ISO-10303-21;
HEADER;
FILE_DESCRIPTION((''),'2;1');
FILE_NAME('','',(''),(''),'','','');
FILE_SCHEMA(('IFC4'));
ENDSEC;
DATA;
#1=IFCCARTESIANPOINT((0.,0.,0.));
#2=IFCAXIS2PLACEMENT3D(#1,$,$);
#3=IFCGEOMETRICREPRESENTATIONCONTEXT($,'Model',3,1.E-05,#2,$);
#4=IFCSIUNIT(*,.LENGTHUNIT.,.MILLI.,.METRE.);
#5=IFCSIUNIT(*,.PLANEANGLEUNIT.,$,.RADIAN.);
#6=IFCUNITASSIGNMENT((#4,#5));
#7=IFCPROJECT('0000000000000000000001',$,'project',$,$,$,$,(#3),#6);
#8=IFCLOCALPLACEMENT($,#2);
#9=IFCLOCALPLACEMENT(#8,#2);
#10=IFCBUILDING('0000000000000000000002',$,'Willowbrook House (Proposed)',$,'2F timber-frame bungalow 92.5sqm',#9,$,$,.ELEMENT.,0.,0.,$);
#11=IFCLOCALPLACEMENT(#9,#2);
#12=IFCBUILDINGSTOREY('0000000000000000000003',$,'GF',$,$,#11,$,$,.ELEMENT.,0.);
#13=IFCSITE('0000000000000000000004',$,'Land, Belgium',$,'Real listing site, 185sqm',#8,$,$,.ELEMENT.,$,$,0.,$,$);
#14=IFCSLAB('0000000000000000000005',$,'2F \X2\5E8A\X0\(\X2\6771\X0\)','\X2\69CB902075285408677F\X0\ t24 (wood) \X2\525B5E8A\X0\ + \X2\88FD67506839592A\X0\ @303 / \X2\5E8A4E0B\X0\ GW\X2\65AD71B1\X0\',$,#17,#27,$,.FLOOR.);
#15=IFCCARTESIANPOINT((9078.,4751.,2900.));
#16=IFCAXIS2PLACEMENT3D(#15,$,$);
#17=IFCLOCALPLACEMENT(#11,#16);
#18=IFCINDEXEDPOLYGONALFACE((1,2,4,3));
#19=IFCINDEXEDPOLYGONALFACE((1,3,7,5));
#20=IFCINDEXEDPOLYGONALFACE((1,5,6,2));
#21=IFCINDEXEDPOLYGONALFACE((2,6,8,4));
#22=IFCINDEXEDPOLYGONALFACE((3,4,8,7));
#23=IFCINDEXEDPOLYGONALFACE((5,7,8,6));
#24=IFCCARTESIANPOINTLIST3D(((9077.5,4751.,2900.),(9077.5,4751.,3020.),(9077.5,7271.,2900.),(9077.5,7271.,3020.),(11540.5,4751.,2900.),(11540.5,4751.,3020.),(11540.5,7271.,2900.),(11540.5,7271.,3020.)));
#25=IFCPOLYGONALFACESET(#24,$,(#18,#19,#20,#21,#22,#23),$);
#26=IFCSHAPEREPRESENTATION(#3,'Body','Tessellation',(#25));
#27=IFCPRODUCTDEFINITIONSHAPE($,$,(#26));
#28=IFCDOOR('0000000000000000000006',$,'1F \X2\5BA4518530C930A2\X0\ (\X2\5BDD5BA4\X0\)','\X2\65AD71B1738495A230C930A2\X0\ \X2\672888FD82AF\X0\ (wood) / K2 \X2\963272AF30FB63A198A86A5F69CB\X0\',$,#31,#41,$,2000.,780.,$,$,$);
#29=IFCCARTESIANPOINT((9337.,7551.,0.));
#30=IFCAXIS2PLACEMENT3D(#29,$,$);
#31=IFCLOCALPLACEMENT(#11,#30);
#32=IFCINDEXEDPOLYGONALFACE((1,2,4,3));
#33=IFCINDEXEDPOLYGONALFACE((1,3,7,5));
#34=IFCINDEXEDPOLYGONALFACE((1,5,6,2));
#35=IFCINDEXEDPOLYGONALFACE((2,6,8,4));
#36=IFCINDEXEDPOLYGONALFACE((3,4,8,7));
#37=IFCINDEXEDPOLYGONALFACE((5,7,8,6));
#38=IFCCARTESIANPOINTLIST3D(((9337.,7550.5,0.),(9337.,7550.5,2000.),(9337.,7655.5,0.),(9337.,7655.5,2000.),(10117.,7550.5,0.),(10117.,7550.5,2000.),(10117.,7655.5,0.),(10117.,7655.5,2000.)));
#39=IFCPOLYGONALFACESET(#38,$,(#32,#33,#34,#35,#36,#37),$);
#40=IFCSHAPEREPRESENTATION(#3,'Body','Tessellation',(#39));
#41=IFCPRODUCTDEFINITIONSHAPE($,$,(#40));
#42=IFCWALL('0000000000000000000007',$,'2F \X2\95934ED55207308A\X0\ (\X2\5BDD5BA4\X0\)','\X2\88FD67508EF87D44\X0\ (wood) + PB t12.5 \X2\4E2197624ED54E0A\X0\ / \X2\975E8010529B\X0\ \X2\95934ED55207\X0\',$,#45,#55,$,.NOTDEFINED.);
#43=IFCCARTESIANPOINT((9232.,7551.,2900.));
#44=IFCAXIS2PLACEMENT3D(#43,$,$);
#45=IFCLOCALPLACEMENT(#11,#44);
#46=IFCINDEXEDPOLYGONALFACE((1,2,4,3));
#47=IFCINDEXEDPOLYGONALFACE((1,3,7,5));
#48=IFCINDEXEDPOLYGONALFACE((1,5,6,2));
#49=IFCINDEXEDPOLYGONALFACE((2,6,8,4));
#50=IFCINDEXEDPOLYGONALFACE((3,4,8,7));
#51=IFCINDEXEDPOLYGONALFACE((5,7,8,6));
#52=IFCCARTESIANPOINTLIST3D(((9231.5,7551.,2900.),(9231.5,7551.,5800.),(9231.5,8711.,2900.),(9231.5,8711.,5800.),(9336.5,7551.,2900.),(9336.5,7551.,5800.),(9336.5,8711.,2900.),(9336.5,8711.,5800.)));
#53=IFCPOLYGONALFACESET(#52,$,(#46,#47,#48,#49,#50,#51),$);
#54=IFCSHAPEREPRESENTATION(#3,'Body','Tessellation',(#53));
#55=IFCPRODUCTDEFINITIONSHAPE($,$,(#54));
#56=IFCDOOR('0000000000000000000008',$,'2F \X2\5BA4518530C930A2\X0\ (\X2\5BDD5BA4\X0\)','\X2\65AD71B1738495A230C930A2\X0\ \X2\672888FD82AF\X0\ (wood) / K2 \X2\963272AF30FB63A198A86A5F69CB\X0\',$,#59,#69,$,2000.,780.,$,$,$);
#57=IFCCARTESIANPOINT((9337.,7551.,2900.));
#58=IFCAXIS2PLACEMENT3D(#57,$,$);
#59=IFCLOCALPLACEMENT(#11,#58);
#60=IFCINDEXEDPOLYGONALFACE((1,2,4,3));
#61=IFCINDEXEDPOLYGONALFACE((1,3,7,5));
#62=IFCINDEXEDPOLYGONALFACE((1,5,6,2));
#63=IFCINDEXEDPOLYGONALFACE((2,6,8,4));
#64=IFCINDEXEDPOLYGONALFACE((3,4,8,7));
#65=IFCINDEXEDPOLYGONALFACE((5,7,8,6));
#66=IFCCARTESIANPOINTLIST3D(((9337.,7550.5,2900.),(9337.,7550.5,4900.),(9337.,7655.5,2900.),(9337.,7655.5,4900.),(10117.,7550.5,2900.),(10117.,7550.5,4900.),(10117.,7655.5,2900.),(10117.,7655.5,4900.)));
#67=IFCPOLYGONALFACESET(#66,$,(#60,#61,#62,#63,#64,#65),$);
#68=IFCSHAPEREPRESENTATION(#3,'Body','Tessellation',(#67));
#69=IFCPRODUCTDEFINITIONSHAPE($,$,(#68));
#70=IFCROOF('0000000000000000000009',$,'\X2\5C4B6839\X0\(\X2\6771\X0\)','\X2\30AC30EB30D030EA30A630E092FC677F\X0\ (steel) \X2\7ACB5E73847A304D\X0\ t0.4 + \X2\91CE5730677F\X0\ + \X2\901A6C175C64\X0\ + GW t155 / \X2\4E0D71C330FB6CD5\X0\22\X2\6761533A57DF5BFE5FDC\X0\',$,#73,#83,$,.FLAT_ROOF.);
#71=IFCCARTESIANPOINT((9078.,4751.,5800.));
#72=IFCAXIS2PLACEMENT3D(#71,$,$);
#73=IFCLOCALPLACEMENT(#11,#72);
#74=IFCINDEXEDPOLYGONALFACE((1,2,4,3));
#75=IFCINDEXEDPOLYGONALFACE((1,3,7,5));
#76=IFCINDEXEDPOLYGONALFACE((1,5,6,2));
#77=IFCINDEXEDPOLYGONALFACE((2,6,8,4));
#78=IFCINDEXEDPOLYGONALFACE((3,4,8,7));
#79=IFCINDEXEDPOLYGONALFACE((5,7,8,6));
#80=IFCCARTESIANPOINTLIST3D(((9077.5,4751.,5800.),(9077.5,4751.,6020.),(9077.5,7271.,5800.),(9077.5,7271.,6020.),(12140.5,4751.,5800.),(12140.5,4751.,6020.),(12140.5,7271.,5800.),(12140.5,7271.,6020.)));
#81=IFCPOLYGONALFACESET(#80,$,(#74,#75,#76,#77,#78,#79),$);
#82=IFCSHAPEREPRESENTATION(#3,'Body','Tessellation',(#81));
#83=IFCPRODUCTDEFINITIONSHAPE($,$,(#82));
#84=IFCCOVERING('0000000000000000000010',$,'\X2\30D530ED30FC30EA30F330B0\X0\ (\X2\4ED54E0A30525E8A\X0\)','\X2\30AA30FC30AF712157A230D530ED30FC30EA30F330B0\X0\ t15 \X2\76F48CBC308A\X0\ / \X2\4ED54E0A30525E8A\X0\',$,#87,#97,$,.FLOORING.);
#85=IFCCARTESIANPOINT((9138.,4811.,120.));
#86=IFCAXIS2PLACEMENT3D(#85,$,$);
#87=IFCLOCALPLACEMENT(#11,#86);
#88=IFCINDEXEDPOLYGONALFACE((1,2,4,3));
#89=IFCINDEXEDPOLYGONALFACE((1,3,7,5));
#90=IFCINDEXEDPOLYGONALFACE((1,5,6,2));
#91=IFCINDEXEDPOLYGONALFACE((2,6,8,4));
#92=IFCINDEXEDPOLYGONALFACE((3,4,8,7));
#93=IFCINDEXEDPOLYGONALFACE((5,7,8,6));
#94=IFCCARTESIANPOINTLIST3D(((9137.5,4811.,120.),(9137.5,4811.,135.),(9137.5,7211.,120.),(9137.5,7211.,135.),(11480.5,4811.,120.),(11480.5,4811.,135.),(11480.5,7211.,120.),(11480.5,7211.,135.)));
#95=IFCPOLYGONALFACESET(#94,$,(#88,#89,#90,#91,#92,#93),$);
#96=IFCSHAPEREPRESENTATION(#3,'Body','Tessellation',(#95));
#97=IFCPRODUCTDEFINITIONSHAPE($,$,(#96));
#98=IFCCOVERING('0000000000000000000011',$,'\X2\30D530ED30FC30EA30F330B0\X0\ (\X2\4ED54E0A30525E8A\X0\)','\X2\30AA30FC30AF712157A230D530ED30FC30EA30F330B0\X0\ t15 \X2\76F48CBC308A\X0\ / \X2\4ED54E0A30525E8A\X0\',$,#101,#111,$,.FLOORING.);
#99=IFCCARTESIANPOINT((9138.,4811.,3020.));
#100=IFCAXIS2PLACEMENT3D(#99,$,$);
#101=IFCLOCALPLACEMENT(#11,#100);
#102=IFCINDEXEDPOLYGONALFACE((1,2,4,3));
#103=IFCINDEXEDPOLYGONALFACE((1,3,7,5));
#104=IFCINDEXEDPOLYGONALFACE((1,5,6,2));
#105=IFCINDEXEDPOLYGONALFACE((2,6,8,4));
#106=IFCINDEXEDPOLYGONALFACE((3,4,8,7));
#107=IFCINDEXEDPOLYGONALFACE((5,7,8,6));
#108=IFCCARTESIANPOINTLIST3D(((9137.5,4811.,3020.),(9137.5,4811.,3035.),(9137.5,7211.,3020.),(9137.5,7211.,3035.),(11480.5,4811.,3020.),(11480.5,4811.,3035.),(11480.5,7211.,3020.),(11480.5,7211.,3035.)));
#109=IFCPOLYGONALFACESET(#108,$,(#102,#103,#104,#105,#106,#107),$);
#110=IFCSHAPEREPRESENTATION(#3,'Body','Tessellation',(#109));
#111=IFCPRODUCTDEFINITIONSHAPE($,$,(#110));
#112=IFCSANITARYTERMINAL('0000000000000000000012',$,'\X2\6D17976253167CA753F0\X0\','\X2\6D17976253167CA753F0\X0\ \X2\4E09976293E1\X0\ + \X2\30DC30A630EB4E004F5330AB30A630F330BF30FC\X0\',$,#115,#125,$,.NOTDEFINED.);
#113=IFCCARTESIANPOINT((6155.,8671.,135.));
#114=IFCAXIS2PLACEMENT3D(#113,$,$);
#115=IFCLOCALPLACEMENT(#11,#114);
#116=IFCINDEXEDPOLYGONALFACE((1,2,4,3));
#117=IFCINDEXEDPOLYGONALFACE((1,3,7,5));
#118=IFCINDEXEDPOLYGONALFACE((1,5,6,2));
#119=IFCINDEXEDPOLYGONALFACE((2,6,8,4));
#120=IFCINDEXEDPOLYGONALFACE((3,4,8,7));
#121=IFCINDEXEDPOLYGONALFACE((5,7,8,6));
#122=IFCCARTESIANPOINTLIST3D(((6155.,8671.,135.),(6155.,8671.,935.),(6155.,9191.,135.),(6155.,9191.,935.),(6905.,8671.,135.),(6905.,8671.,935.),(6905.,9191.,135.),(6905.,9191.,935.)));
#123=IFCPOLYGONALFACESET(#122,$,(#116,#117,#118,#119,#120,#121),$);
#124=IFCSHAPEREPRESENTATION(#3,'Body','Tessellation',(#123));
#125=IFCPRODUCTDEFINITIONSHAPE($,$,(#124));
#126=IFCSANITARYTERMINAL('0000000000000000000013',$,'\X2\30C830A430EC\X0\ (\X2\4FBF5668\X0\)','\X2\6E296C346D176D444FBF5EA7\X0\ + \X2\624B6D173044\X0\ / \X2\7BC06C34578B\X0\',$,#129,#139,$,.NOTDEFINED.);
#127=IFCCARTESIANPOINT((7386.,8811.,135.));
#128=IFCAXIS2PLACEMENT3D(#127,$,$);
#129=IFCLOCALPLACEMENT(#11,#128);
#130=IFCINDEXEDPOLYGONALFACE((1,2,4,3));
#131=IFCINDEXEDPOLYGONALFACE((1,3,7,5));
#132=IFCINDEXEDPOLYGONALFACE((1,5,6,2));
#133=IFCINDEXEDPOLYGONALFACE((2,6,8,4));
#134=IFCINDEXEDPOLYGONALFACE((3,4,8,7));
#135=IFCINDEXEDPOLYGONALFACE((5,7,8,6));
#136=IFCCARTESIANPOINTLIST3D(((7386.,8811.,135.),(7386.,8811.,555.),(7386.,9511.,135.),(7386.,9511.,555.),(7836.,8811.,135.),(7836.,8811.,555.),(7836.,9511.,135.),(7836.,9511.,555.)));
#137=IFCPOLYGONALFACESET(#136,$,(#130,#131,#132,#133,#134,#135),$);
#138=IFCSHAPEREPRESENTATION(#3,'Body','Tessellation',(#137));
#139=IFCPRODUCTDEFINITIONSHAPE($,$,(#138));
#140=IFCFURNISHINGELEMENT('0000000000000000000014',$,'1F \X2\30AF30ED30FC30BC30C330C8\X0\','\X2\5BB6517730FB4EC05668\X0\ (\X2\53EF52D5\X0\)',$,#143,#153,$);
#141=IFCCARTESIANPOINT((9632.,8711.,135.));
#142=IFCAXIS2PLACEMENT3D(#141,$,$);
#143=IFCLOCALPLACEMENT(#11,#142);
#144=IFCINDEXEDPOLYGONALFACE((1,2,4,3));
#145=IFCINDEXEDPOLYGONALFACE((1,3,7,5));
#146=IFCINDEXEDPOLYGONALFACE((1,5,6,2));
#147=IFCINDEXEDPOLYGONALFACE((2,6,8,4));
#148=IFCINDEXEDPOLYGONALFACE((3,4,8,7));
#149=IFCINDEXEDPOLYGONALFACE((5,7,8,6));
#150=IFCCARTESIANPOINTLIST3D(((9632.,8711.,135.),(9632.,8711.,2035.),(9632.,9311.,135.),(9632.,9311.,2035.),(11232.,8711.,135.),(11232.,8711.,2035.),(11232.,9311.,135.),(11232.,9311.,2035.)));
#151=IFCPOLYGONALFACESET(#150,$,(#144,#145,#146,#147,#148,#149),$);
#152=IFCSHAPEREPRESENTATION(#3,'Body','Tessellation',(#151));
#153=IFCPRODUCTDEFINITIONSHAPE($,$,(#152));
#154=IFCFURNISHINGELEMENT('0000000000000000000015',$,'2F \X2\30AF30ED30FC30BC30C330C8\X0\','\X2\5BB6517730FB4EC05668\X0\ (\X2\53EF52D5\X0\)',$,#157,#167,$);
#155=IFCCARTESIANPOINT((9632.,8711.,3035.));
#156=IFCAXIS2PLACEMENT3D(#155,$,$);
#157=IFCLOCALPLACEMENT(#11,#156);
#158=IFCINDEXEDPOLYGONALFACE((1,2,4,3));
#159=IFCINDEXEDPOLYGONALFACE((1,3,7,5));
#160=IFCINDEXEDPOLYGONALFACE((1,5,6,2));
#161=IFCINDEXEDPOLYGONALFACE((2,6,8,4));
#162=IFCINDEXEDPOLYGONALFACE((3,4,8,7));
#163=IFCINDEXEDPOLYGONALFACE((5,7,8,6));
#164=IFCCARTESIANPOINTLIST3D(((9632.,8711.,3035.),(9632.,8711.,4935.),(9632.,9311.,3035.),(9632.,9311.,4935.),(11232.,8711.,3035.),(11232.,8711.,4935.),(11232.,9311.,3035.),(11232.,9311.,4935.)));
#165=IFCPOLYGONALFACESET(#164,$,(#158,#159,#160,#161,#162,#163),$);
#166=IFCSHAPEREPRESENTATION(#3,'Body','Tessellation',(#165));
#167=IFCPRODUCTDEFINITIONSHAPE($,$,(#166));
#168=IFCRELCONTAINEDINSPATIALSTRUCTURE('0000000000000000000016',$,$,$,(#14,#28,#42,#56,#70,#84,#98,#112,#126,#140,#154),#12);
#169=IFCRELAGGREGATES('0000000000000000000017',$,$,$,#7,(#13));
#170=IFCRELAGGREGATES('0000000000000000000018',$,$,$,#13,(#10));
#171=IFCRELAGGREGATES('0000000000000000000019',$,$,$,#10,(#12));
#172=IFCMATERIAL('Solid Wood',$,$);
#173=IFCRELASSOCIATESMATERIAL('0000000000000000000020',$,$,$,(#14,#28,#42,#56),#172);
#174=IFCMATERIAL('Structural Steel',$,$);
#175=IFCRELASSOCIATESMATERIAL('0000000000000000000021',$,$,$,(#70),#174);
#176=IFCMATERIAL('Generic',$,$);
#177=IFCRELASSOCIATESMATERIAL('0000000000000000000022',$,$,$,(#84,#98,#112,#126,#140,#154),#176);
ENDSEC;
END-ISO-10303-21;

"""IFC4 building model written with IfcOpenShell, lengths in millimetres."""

from ifc_helpers import new_model, si_unit, frame, frame_2d, origin, place, context, project, spatial, rectangle, extrude, material, element, save


model = new_model("IFC4")

# Units and contexts
model_context = context("Model", 3, precision=1e-05, world=origin())
ifc_project = project(units=[si_unit("LENGTHUNIT", "METRE", prefix="MILLI"), si_unit("PLANEANGLEUNIT", "RADIAN")], contexts=[model_context])

# Site, building, storey
site_placement = place(None, origin())
site = spatial("IfcSite", under=ifc_project, at=site_placement, Name="Land, Belgium", ObjectType="Real listing site, 185sqm", CompositionType="ELEMENT", RefElevation=0.0)
building_placement = place(site_placement, origin())
building = spatial("IfcBuilding", under=site, at=building_placement, Name="Willowbrook House (Proposed)", ObjectType="2F timber-frame bungalow 92.5sqm", CompositionType="ELEMENT", ElevationOfRefHeight=0.0, ElevationOfTerrain=0.0)
storey_placement = place(building_placement, origin())
storey = spatial("IfcBuildingStorey", under=building, at=storey_placement, Name="GF", CompositionType="ELEMENT", Elevation=0.0)

# Slab
ifc_material_1 = material(Name="Solid Wood")
slab_1_placement = place(storey_placement, frame((9078.0, 4751.0, 2900.0)))
element("IfcSlab", 1, at=slab_1_placement, inside=storey, material=ifc_material_1, Name="2F 床(東)", Description="構造用合板 t24 (wood) 剛床 + 製材根太 @303 / 床下 GW断熱", PredefinedType="FLOOR", context=model_context, shape_type="SweptSolid", body=[
    extrude(rectangle(XDim=2463.0, YDim=2520.0, at=frame_2d((1231.0, 1260.0))), frame((9078.0, 4751.0, 2900.0)), (0.0, 0.0, 1.0), 120.0),
])

# Door
door_1_placement = place(storey_placement, frame((9337.0, 7551.0, 0.0)))
element("IfcDoor", 2, at=door_1_placement, inside=storey, material=ifc_material_1, Name="1F 室内ドア (寝室)", Description="断熱玄関ドア 木製芯 (wood) / K2 防犯・採風機構", OverallHeight=2000.0, OverallWidth=780.0, context=model_context, shape_type="SweptSolid", body=[
    extrude(rectangle(XDim=780.0, YDim=105.0, at=frame_2d((390.0, 52.0))), frame((9337.0, 7551.0, 0.0)), (0.0, 0.0, 1.0), 2000.0),
])

# Wall
wall_1_placement = place(storey_placement, frame((9232.0, 7551.0, 2900.0)))
element("IfcWall", 3, at=wall_1_placement, inside=storey, material=ifc_material_1, Name="2F 間仕切り (寝室)", Description="製材軸組 (wood) + PB t12.5 両面仕上 / 非耐力 間仕切", PredefinedType="NOTDEFINED", context=model_context, shape_type="SweptSolid", body=[
    extrude(rectangle(XDim=105.0, YDim=1160.0, at=frame_2d((52.0, 580.0))), frame((9232.0, 7551.0, 2900.0)), (0.0, 0.0, 1.0), 2900.0),
])

# Door
door_2_placement = place(storey_placement, frame((9337.0, 7551.0, 2900.0)))
element("IfcDoor", 4, at=door_2_placement, inside=storey, material=ifc_material_1, Name="2F 室内ドア (寝室)", Description="断熱玄関ドア 木製芯 (wood) / K2 防犯・採風機構", OverallHeight=2000.0, OverallWidth=780.0, context=model_context, shape_type="SweptSolid", body=[
    extrude(rectangle(XDim=780.0, YDim=105.0, at=frame_2d((390.0, 52.0))), frame((9337.0, 7551.0, 2900.0)), (0.0, 0.0, 1.0), 2000.0),
])

# Roof
ifc_material_2 = material(Name="Structural Steel")
for number, where, name in (
    (5, (9078.0, 4751.0, 5800.0), "屋根(東)"),
):
    element("IfcRoof", number, at=place(storey_placement, frame(where)), inside=storey, material=ifc_material_2, Name=name, Description="ガルバリウム鋼板 (steel) 立平葺き t0.4 + 野地板 + 通気層 + GW t155 / 不燃・法22条区域対応", PredefinedType="FLAT_ROOF", context=model_context, shape_type="SweptSolid", body=[
        extrude(rectangle(XDim=3063.0, YDim=2520.0, at=frame_2d((1531.0, 1260.0))), frame((9078.0, 4751.0, 5800.0)), (0.0, 0.0, 1.0), 220.0),
    ])

# Coverings
ifc_material_3 = material(Name="Generic")
covering_1_placement = place(storey_placement, frame((9138.0, 4811.0, 120.0)))
element("IfcCovering", 6, at=covering_1_placement, inside=storey, material=ifc_material_3, Name="フローリング (仕上げ床)", Description="オーク無垢フローリング t15 直貼り / 仕上げ床", PredefinedType="FLOORING", context=model_context, shape_type="SweptSolid", body=[
    extrude(rectangle(XDim=2343.0, YDim=2400.0, at=frame_2d((1171.0, 1200.0))), frame((9138.0, 4811.0, 120.0)), (0.0, 0.0, 1.0), 15.0),
])
covering_2_placement = place(storey_placement, frame((9138.0, 4811.0, 3020.0)))
element("IfcCovering", 7, at=covering_2_placement, inside=storey, material=ifc_material_3, Name="フローリング (仕上げ床)", Description="オーク無垢フローリング t15 直貼り / 仕上げ床", PredefinedType="FLOORING", context=model_context, shape_type="SweptSolid", body=[
    extrude(rectangle(XDim=2343.0, YDim=2400.0, at=frame_2d((1171.0, 1200.0))), frame((9138.0, 4811.0, 3020.0)), (0.0, 0.0, 1.0), 15.0),
])

# Sanitary terminals
sanitary_terminal_1_placement = place(storey_placement, frame((6155.0, 8671.0, 135.0)))
element("IfcSanitaryTerminal", 8, at=sanitary_terminal_1_placement, inside=storey, material=ifc_material_3, Name="洗面化粧台", Description="洗面化粧台 三面鏡 + ボウル一体カウンター", PredefinedType="NOTDEFINED", context=model_context, shape_type="SweptSolid", body=[
    extrude(rectangle(XDim=750.0, YDim=520.0, at=frame_2d((375.0, 260.0))), frame((6155.0, 8671.0, 135.0)), (0.0, 0.0, 1.0), 800.0),
])
sanitary_terminal_2_placement = place(storey_placement, frame((7386.0, 8811.0, 135.0)))
element("IfcSanitaryTerminal", 9, at=sanitary_terminal_2_placement, inside=storey, material=ifc_material_3, Name="トイレ (便器)", Description="温水洗浄便座 + 手洗い / 節水型", PredefinedType="NOTDEFINED", context=model_context, shape_type="SweptSolid", body=[
    extrude(rectangle(XDim=450.0, YDim=700.0, at=frame_2d((225.0, 350.0))), frame((7386.0, 8811.0, 135.0)), (0.0, 0.0, 1.0), 420.0),
])

# Furnishing elements
furnishing_1_placement = place(storey_placement, frame((9632.0, 8711.0, 135.0)))
element("IfcFurnishingElement", 10, at=furnishing_1_placement, inside=storey, material=ifc_material_3, Name="1F クローゼット", Description="家具・什器 (可動)", context=model_context, shape_type="SweptSolid", body=[
    extrude(rectangle(XDim=1600.0, YDim=600.0, at=frame_2d((800.0, 300.0))), frame((9632.0, 8711.0, 135.0)), (0.0, 0.0, 1.0), 1900.0),
])
furnishing_2_placement = place(storey_placement, frame((9632.0, 8711.0, 3035.0)))
element("IfcFurnishingElement", 11, at=furnishing_2_placement, inside=storey, material=ifc_material_3, Name="2F クローゼット", Description="家具・什器 (可動)", context=model_context, shape_type="SweptSolid", body=[
    extrude(rectangle(XDim=1600.0, YDim=600.0, at=frame_2d((800.0, 300.0))), frame((9632.0, 8711.0, 3035.0)), (0.0, 0.0, 1.0), 1900.0),
])

save(model, "model.ifc")
